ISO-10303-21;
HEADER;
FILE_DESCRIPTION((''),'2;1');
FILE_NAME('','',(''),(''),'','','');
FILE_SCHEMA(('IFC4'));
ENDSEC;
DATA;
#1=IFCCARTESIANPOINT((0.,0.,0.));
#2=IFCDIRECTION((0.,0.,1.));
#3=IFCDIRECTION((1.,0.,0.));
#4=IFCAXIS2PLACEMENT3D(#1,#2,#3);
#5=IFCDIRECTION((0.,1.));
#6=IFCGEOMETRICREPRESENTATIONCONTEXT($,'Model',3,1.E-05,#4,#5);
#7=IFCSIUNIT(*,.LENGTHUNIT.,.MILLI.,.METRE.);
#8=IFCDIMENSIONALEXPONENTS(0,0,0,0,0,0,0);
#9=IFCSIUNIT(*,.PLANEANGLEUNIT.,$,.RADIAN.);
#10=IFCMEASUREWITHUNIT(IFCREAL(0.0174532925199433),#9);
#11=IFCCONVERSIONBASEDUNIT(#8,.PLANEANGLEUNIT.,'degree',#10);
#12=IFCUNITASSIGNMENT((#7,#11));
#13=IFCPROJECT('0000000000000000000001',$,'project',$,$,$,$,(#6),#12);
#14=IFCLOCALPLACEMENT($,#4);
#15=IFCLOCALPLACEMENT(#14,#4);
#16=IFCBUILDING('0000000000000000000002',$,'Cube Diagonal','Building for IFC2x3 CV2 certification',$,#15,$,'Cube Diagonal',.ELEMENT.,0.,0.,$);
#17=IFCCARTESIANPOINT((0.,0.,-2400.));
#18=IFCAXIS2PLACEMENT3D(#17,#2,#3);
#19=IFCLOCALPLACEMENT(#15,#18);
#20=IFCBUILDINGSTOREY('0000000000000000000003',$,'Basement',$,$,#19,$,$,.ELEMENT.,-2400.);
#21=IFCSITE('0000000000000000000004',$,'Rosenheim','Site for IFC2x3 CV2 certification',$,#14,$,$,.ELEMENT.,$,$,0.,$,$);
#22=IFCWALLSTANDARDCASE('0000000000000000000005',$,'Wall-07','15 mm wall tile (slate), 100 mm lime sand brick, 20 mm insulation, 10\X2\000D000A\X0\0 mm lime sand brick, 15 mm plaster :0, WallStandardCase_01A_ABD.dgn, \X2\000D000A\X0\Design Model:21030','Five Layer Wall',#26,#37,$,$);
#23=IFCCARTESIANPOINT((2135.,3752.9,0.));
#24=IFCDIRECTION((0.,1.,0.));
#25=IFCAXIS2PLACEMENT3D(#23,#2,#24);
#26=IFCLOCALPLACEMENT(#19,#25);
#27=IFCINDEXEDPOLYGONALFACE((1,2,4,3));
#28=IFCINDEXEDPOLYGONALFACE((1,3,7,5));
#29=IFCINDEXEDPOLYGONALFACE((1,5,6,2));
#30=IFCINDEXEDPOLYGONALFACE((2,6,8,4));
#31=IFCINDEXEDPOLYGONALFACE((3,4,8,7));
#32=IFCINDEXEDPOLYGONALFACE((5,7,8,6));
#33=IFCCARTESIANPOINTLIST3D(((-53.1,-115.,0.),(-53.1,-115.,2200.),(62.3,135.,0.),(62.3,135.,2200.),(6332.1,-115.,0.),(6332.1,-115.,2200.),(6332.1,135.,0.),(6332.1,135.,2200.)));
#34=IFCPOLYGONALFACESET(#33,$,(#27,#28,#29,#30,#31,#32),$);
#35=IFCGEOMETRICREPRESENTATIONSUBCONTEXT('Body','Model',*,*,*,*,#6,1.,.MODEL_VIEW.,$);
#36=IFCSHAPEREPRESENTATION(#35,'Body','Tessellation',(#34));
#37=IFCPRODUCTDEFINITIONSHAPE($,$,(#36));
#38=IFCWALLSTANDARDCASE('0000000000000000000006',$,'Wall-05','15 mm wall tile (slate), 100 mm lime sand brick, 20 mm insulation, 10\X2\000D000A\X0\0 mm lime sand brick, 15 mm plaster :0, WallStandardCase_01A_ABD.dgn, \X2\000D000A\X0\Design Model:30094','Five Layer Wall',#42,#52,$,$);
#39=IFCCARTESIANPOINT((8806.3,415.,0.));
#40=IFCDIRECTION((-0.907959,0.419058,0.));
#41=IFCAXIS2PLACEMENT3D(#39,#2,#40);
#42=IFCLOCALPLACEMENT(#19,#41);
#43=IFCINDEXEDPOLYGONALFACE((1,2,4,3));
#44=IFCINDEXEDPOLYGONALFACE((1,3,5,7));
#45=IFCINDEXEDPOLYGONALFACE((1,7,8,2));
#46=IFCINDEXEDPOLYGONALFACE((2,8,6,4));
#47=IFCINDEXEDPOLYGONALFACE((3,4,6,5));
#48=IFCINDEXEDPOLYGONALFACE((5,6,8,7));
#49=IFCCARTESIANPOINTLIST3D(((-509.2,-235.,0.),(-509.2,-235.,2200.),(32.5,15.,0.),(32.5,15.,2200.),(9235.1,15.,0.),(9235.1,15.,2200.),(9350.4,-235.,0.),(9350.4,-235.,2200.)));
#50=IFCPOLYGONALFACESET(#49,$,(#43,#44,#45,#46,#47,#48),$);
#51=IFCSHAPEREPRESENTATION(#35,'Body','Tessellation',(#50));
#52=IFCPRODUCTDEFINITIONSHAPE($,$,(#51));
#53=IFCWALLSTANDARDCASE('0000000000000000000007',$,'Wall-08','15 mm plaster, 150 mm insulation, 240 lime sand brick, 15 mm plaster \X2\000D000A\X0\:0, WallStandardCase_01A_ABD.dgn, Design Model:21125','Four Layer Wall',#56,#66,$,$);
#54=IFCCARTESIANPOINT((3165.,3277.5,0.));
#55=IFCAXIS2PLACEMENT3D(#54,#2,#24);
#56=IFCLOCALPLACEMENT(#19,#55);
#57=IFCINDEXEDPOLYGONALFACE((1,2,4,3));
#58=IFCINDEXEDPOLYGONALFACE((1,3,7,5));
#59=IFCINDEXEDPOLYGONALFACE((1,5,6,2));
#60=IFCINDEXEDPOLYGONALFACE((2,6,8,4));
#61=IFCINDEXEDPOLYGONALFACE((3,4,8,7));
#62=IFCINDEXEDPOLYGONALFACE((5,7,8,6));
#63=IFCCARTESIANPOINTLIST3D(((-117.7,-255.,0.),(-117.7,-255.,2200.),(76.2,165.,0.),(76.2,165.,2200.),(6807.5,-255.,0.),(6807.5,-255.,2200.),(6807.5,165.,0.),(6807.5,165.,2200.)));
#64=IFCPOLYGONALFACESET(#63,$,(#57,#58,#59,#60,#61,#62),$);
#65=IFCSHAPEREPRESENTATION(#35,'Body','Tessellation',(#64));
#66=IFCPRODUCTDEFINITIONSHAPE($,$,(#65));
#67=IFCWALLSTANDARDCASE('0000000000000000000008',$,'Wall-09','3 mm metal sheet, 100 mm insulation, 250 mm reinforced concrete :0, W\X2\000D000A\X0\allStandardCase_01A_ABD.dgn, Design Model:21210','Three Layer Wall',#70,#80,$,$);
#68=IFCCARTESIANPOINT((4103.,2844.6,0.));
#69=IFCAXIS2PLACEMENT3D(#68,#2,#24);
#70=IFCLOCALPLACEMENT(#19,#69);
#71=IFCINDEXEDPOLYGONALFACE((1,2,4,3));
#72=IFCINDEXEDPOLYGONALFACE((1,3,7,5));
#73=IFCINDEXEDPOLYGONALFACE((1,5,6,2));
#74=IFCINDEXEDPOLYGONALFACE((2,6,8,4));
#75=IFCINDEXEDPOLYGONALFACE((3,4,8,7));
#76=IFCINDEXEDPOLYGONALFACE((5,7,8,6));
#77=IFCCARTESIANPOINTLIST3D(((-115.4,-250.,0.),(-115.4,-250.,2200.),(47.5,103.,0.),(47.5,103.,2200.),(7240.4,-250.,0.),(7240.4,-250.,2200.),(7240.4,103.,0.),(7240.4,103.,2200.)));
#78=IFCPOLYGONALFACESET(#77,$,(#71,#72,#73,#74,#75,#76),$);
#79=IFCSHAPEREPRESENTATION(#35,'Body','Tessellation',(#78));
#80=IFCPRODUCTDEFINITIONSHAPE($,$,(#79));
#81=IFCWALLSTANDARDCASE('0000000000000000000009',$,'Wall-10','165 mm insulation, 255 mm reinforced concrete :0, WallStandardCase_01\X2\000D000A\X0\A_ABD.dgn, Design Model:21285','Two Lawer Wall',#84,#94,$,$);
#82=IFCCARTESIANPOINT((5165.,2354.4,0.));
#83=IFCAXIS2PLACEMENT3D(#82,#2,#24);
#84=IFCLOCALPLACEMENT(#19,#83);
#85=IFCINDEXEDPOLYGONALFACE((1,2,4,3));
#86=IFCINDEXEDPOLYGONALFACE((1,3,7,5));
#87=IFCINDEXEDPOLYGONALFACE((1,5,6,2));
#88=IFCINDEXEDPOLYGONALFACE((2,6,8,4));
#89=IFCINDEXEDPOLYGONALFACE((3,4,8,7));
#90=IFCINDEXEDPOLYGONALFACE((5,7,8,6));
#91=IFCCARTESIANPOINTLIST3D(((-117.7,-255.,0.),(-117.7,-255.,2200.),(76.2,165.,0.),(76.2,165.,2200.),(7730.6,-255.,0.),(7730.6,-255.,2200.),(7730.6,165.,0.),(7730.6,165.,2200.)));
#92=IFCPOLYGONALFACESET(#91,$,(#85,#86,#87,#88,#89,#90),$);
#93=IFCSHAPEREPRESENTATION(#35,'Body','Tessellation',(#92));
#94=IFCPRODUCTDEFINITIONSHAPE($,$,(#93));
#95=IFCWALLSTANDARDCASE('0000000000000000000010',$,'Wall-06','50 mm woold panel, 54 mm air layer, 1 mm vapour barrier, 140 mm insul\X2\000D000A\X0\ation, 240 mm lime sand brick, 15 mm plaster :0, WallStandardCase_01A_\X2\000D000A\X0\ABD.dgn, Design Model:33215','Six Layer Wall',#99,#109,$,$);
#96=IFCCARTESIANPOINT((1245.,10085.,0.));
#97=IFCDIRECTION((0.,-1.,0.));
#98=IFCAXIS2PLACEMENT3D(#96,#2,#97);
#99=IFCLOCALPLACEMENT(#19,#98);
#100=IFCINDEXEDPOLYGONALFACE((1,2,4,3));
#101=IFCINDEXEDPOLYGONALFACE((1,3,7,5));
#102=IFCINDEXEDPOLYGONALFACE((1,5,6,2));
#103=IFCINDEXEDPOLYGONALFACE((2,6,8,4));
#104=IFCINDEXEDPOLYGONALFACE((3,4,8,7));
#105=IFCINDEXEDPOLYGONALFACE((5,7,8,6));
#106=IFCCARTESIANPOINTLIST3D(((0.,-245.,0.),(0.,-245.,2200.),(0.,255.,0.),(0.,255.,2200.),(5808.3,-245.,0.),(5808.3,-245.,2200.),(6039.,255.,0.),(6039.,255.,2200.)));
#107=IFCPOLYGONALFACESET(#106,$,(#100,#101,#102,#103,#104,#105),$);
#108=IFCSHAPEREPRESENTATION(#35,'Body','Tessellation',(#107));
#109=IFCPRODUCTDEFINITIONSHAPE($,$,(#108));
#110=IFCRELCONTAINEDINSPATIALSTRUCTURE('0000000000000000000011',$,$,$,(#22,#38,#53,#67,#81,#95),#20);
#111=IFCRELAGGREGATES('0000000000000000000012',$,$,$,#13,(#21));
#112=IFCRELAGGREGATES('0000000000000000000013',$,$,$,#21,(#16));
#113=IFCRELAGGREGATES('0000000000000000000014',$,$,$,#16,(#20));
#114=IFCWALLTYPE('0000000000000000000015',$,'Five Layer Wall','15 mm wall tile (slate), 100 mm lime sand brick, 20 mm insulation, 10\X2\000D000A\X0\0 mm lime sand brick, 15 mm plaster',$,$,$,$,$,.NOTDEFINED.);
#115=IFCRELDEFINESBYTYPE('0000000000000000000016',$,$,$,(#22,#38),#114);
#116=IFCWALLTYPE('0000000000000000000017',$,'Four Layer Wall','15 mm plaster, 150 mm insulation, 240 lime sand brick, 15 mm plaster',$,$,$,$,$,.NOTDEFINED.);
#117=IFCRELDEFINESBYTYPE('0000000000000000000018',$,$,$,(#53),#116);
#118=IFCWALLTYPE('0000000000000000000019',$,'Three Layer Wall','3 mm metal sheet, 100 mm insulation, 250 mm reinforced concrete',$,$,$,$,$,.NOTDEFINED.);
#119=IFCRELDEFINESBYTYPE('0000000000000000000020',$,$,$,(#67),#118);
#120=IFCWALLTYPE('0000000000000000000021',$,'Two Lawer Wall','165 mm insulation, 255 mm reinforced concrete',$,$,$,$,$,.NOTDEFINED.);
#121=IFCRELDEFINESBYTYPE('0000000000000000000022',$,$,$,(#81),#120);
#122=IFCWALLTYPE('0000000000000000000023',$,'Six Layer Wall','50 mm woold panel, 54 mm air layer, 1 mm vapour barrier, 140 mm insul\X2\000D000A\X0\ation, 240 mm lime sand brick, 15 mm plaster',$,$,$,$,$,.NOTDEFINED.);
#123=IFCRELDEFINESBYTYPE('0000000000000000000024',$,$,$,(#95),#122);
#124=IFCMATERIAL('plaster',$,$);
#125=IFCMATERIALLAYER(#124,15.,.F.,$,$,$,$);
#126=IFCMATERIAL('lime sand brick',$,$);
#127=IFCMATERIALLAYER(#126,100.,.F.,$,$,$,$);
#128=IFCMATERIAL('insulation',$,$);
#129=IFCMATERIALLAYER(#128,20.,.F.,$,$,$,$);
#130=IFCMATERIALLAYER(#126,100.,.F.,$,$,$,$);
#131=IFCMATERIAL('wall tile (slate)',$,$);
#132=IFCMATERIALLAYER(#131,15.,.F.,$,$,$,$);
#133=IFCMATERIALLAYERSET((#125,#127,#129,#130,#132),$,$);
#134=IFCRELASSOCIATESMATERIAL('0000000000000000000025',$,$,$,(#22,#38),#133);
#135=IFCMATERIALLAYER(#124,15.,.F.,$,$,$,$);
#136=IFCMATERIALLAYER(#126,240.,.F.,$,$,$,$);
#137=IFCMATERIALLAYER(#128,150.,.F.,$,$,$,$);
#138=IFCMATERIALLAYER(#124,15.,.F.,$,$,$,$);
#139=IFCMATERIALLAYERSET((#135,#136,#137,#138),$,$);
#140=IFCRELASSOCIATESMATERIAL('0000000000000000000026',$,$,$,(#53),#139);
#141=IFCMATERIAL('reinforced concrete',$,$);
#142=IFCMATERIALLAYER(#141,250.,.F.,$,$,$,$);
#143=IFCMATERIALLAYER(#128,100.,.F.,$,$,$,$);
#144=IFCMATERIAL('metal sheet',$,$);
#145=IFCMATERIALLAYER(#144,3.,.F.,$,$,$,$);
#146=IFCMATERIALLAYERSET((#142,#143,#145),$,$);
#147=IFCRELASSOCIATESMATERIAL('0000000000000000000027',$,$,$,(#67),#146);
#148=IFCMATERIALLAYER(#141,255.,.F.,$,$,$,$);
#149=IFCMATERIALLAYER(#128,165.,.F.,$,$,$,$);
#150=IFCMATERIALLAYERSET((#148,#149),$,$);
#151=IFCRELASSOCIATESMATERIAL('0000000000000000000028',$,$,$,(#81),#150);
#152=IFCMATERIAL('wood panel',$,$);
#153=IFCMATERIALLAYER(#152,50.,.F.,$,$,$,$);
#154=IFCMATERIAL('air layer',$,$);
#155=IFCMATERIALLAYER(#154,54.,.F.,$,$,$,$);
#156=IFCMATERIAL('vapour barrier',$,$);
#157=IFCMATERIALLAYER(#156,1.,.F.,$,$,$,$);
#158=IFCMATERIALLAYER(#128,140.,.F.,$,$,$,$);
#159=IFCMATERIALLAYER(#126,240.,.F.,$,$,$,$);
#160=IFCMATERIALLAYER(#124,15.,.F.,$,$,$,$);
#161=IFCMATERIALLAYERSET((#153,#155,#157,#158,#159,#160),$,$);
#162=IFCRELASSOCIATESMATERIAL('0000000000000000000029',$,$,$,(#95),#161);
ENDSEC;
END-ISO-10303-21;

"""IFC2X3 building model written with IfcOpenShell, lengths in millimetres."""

from ifc_helpers import new_model, entity, si_unit, converted_unit, direction, frame, origin_with_axes, place, context, subcontext, project, spatial, polyline, outline, extrude, material, layer, layer_set, layer_usage, type_object, element, save


model = new_model("IFC2X3")

# Units and contexts
model_context = context("Model", 3, precision=1e-05, world=origin_with_axes(), true_north=direction((0.0, 1.0)))
body_context = subcontext(model_context, "Body", "Model", "MODEL_VIEW", scale=1.0)
ifc_project = project(units=[si_unit("LENGTHUNIT", "METRE", prefix="MILLI"), converted_unit("PLANEANGLEUNIT", "degree", entity("IfcReal", 0.0174532925199433), si_unit("PLANEANGLEUNIT", "RADIAN"), dimensions=[0, 0, 0, 0, 0, 0, 0])], contexts=[model_context])

# Site, building, storey
site_placement = place(None, origin_with_axes())
site = spatial("IfcSite", under=ifc_project, at=site_placement, Name="Rosenheim", Description="Site for IFC2x3 CV2 certification", CompositionType="ELEMENT", RefElevation=0.0)
building_placement = place(site_placement, origin_with_axes())
building = spatial("IfcBuilding", under=site, at=building_placement, Name="Cube Diagonal", Description="Building for IFC2x3 CV2 certification", LongName="Cube Diagonal", CompositionType="ELEMENT", ElevationOfRefHeight=0.0, ElevationOfTerrain=0.0)
storey_placement = place(building_placement, frame((0.0, 0.0, -2400.0), z_axis=(0.0, 0.0, 1.0), x_axis=(1.0, 0.0, 0.0)))
storey = spatial("IfcBuildingStorey", under=building, at=storey_placement, Name="Basement", CompositionType="ELEMENT", Elevation=-2400.0)

# Walls
ifc_material_1 = material(Name="lime sand brick")
ifc_material_2 = material(Name="reinforced concrete")
ifc_material_3 = material(Name="plaster")
ifc_layer_1 = layer(ifc_material_3, 15.0, ventilated=False)
ifc_layer_2 = layer(ifc_material_1, 100.0, ventilated=False)
ifc_material_4 = material(Name="insulation")
ifc_layer_3 = layer(ifc_material_4, 20.0, ventilated=False)
ifc_layer_4 = layer(ifc_material_1, 100.0, ventilated=False)
ifc_material_5 = material(Name="wall tile (slate)")
ifc_layer_5 = layer(ifc_material_5, 15.0, ventilated=False)
ifc_layer_set_1 = layer_set([ifc_layer_1, ifc_layer_2, ifc_layer_3, ifc_layer_4, ifc_layer_5])
ifc_layer_usage_1 = layer_usage(ifc_layer_set_1, "AXIS2", "POSITIVE", 0.0)
wall_type_1 = type_object("IfcWallType", Name="Five Layer Wall", Description="15 mm wall tile (slate), 100 mm lime sand brick, 20 mm insulation, 10\r\n0 mm lime sand brick, 15 mm plaster", PredefinedType="NOTDEFINED")
wall_1_placement = place(storey_placement, frame((2135.0, 3752.9, 0.0), z_axis=(0.0, 0.0, 1.0), x_axis=(0.0, 1.0, 0.0)))
element("IfcWallStandardCase", 1, at=wall_1_placement, inside=storey, type_object=wall_type_1, material=ifc_layer_usage_1, Name="Wall-07", Description="15 mm wall tile (slate), 100 mm lime sand brick, 20 mm insulation, 10\r\n0 mm lime sand brick, 15 mm plaster :0, WallStandardCase_01A_ABD.dgn, \r\nDesign Model:21030", ObjectType="Five Layer Wall", context=body_context, shape_type="SweptSolid", body=[
    extrude(outline(polyline([(-53.1, -115.0), (6332.1, -115.0), (6332.1, 135.0), (62.3, 135.0), (-53.1, -115.0)])), origin_with_axes(), (0.0, 0.0, 1.0), 2200.0),
])
wall_2_placement = place(storey_placement, frame((8806.3, 415.0, 0.0), z_axis=(0.0, 0.0, 1.0), x_axis=(-0.907959, 0.419058, 0.0)))
element("IfcWallStandardCase", 2, at=wall_2_placement, inside=storey, type_object=wall_type_1, material=ifc_layer_usage_1, Name="Wall-05", Description="15 mm wall tile (slate), 100 mm lime sand brick, 20 mm insulation, 10\r\n0 mm lime sand brick, 15 mm plaster :0, WallStandardCase_01A_ABD.dgn, \r\nDesign Model:30094", ObjectType="Five Layer Wall", context=body_context, shape_type="SweptSolid", body=[
    extrude(outline(polyline([(9235.1, 15.0), (32.5, 15.0), (-509.2, -235.0), (9350.4, -235.0), (9235.1, 15.0)])), origin_with_axes(), (0.0, 0.0, 1.0), 2200.0),
])
ifc_layer_6 = layer(ifc_material_3, 15.0, ventilated=False)
ifc_layer_7 = layer(ifc_material_1, 240.0, ventilated=False)
ifc_layer_8 = layer(ifc_material_4, 150.0, ventilated=False)
ifc_layer_9 = layer(ifc_material_3, 15.0, ventilated=False)
ifc_layer_set_2 = layer_set([ifc_layer_6, ifc_layer_7, ifc_layer_8, ifc_layer_9])
ifc_layer_usage_2 = layer_usage(ifc_layer_set_2, "AXIS2", "POSITIVE", 0.0)
wall_type_2 = type_object("IfcWallType", Name="Four Layer Wall", Description="15 mm plaster, 150 mm insulation, 240 lime sand brick, 15 mm plaster", PredefinedType="NOTDEFINED")
wall_3_placement = place(storey_placement, frame((3165.0, 3277.5, 0.0), z_axis=(0.0, 0.0, 1.0), x_axis=(0.0, 1.0, 0.0)))
element("IfcWallStandardCase", 3, at=wall_3_placement, inside=storey, type_object=wall_type_2, material=ifc_layer_usage_2, Name="Wall-08", Description="15 mm plaster, 150 mm insulation, 240 lime sand brick, 15 mm plaster \r\n:0, WallStandardCase_01A_ABD.dgn, Design Model:21125", ObjectType="Four Layer Wall", context=body_context, shape_type="SweptSolid", body=[
    extrude(outline(polyline([(-117.7, -255.0), (6807.5, -255.0), (6807.5, 165.0), (76.2, 165.0), (-117.7, -255.0)])), origin_with_axes(), (0.0, 0.0, 1.0), 2200.0),
])
ifc_layer_10 = layer(ifc_material_2, 250.0, ventilated=False)
ifc_layer_11 = layer(ifc_material_4, 100.0, ventilated=False)
ifc_material_6 = material(Name="metal sheet")
ifc_layer_12 = layer(ifc_material_6, 3.0, ventilated=False)
ifc_layer_set_3 = layer_set([ifc_layer_10, ifc_layer_11, ifc_layer_12])
ifc_layer_usage_3 = layer_usage(ifc_layer_set_3, "AXIS2", "POSITIVE", 0.0)
wall_type_3 = type_object("IfcWallType", Name="Three Layer Wall", Description="3 mm metal sheet, 100 mm insulation, 250 mm reinforced concrete", PredefinedType="NOTDEFINED")
wall_4_placement = place(storey_placement, frame((4103.0, 2844.6, 0.0), z_axis=(0.0, 0.0, 1.0), x_axis=(0.0, 1.0, 0.0)))
element("IfcWallStandardCase", 4, at=wall_4_placement, inside=storey, type_object=wall_type_3, material=ifc_layer_usage_3, Name="Wall-09", Description="3 mm metal sheet, 100 mm insulation, 250 mm reinforced concrete :0, W\r\nallStandardCase_01A_ABD.dgn, Design Model:21210", ObjectType="Three Layer Wall", context=body_context, shape_type="SweptSolid", body=[
    extrude(outline(polyline([(-115.4, -250.0), (7240.4, -250.0), (7240.4, 103.0), (47.5, 103.0), (-115.4, -250.0)])), origin_with_axes(), (0.0, 0.0, 1.0), 2200.0),
])
ifc_layer_13 = layer(ifc_material_2, 255.0, ventilated=False)
ifc_layer_14 = layer(ifc_material_4, 165.0, ventilated=False)
ifc_layer_set_4 = layer_set([ifc_layer_13, ifc_layer_14])
ifc_layer_usage_4 = layer_usage(ifc_layer_set_4, "AXIS2", "POSITIVE", 0.0)
wall_type_4 = type_object("IfcWallType", Name="Two Lawer Wall", Description="165 mm insulation, 255 mm reinforced concrete", PredefinedType="NOTDEFINED")
wall_5_placement = place(storey_placement, frame((5165.0, 2354.4, 0.0), z_axis=(0.0, 0.0, 1.0), x_axis=(0.0, 1.0, 0.0)))
element("IfcWallStandardCase", 5, at=wall_5_placement, inside=storey, type_object=wall_type_4, material=ifc_layer_usage_4, Name="Wall-10", Description="165 mm insulation, 255 mm reinforced concrete :0, WallStandardCase_01\r\nA_ABD.dgn, Design Model:21285", ObjectType="Two Lawer Wall", context=body_context, shape_type="SweptSolid", body=[
    extrude(outline(polyline([(-117.7, -255.0), (7730.6, -255.0), (7730.6, 165.0), (76.2, 165.0), (-117.7, -255.0)])), origin_with_axes(), (0.0, 0.0, 1.0), 2200.0),
])
ifc_material_7 = material(Name="wood panel")
ifc_layer_15 = layer(ifc_material_7, 50.0, ventilated=False)
ifc_material_8 = material(Name="air layer")
ifc_layer_16 = layer(ifc_material_8, 54.0, ventilated=False)
ifc_material_9 = material(Name="vapour barrier")
ifc_layer_17 = layer(ifc_material_9, 1.0, ventilated=False)
ifc_layer_18 = layer(ifc_material_4, 140.0, ventilated=False)
ifc_layer_19 = layer(ifc_material_1, 240.0, ventilated=False)
ifc_layer_20 = layer(ifc_material_3, 15.0, ventilated=False)
ifc_layer_set_5 = layer_set([ifc_layer_15, ifc_layer_16, ifc_layer_17, ifc_layer_18, ifc_layer_19, ifc_layer_20])
ifc_layer_usage_5 = layer_usage(ifc_layer_set_5, "AXIS2", "POSITIVE", 0.0)
wall_type_5 = type_object("IfcWallType", Name="Six Layer Wall", Description="50 mm woold panel, 54 mm air layer, 1 mm vapour barrier, 140 mm insul\r\nation, 240 mm lime sand brick, 15 mm plaster", PredefinedType="NOTDEFINED")
wall_6_placement = place(storey_placement, frame((1245.0, 10085.0, 0.0), z_axis=(0.0, 0.0, 1.0), x_axis=(0.0, -1.0, 0.0)))
element("IfcWallStandardCase", 6, at=wall_6_placement, inside=storey, type_object=wall_type_5, material=ifc_layer_usage_5, Name="Wall-06", Description="50 mm woold panel, 54 mm air layer, 1 mm vapour barrier, 140 mm insul\r\nation, 240 mm lime sand brick, 15 mm plaster :0, WallStandardCase_01A_\r\nABD.dgn, Design Model:33215", ObjectType="Six Layer Wall", context=body_context, shape_type="SweptSolid", body=[
    extrude(outline(polyline([(6039.0, 255.0), (0.0, 255.0), (0.0, -245.0), (5808.3, -245.0), (6039.0, 255.0)])), origin_with_axes(), (0.0, 0.0, 1.0), 2200.0),
])

save(model, "model.ifc")
